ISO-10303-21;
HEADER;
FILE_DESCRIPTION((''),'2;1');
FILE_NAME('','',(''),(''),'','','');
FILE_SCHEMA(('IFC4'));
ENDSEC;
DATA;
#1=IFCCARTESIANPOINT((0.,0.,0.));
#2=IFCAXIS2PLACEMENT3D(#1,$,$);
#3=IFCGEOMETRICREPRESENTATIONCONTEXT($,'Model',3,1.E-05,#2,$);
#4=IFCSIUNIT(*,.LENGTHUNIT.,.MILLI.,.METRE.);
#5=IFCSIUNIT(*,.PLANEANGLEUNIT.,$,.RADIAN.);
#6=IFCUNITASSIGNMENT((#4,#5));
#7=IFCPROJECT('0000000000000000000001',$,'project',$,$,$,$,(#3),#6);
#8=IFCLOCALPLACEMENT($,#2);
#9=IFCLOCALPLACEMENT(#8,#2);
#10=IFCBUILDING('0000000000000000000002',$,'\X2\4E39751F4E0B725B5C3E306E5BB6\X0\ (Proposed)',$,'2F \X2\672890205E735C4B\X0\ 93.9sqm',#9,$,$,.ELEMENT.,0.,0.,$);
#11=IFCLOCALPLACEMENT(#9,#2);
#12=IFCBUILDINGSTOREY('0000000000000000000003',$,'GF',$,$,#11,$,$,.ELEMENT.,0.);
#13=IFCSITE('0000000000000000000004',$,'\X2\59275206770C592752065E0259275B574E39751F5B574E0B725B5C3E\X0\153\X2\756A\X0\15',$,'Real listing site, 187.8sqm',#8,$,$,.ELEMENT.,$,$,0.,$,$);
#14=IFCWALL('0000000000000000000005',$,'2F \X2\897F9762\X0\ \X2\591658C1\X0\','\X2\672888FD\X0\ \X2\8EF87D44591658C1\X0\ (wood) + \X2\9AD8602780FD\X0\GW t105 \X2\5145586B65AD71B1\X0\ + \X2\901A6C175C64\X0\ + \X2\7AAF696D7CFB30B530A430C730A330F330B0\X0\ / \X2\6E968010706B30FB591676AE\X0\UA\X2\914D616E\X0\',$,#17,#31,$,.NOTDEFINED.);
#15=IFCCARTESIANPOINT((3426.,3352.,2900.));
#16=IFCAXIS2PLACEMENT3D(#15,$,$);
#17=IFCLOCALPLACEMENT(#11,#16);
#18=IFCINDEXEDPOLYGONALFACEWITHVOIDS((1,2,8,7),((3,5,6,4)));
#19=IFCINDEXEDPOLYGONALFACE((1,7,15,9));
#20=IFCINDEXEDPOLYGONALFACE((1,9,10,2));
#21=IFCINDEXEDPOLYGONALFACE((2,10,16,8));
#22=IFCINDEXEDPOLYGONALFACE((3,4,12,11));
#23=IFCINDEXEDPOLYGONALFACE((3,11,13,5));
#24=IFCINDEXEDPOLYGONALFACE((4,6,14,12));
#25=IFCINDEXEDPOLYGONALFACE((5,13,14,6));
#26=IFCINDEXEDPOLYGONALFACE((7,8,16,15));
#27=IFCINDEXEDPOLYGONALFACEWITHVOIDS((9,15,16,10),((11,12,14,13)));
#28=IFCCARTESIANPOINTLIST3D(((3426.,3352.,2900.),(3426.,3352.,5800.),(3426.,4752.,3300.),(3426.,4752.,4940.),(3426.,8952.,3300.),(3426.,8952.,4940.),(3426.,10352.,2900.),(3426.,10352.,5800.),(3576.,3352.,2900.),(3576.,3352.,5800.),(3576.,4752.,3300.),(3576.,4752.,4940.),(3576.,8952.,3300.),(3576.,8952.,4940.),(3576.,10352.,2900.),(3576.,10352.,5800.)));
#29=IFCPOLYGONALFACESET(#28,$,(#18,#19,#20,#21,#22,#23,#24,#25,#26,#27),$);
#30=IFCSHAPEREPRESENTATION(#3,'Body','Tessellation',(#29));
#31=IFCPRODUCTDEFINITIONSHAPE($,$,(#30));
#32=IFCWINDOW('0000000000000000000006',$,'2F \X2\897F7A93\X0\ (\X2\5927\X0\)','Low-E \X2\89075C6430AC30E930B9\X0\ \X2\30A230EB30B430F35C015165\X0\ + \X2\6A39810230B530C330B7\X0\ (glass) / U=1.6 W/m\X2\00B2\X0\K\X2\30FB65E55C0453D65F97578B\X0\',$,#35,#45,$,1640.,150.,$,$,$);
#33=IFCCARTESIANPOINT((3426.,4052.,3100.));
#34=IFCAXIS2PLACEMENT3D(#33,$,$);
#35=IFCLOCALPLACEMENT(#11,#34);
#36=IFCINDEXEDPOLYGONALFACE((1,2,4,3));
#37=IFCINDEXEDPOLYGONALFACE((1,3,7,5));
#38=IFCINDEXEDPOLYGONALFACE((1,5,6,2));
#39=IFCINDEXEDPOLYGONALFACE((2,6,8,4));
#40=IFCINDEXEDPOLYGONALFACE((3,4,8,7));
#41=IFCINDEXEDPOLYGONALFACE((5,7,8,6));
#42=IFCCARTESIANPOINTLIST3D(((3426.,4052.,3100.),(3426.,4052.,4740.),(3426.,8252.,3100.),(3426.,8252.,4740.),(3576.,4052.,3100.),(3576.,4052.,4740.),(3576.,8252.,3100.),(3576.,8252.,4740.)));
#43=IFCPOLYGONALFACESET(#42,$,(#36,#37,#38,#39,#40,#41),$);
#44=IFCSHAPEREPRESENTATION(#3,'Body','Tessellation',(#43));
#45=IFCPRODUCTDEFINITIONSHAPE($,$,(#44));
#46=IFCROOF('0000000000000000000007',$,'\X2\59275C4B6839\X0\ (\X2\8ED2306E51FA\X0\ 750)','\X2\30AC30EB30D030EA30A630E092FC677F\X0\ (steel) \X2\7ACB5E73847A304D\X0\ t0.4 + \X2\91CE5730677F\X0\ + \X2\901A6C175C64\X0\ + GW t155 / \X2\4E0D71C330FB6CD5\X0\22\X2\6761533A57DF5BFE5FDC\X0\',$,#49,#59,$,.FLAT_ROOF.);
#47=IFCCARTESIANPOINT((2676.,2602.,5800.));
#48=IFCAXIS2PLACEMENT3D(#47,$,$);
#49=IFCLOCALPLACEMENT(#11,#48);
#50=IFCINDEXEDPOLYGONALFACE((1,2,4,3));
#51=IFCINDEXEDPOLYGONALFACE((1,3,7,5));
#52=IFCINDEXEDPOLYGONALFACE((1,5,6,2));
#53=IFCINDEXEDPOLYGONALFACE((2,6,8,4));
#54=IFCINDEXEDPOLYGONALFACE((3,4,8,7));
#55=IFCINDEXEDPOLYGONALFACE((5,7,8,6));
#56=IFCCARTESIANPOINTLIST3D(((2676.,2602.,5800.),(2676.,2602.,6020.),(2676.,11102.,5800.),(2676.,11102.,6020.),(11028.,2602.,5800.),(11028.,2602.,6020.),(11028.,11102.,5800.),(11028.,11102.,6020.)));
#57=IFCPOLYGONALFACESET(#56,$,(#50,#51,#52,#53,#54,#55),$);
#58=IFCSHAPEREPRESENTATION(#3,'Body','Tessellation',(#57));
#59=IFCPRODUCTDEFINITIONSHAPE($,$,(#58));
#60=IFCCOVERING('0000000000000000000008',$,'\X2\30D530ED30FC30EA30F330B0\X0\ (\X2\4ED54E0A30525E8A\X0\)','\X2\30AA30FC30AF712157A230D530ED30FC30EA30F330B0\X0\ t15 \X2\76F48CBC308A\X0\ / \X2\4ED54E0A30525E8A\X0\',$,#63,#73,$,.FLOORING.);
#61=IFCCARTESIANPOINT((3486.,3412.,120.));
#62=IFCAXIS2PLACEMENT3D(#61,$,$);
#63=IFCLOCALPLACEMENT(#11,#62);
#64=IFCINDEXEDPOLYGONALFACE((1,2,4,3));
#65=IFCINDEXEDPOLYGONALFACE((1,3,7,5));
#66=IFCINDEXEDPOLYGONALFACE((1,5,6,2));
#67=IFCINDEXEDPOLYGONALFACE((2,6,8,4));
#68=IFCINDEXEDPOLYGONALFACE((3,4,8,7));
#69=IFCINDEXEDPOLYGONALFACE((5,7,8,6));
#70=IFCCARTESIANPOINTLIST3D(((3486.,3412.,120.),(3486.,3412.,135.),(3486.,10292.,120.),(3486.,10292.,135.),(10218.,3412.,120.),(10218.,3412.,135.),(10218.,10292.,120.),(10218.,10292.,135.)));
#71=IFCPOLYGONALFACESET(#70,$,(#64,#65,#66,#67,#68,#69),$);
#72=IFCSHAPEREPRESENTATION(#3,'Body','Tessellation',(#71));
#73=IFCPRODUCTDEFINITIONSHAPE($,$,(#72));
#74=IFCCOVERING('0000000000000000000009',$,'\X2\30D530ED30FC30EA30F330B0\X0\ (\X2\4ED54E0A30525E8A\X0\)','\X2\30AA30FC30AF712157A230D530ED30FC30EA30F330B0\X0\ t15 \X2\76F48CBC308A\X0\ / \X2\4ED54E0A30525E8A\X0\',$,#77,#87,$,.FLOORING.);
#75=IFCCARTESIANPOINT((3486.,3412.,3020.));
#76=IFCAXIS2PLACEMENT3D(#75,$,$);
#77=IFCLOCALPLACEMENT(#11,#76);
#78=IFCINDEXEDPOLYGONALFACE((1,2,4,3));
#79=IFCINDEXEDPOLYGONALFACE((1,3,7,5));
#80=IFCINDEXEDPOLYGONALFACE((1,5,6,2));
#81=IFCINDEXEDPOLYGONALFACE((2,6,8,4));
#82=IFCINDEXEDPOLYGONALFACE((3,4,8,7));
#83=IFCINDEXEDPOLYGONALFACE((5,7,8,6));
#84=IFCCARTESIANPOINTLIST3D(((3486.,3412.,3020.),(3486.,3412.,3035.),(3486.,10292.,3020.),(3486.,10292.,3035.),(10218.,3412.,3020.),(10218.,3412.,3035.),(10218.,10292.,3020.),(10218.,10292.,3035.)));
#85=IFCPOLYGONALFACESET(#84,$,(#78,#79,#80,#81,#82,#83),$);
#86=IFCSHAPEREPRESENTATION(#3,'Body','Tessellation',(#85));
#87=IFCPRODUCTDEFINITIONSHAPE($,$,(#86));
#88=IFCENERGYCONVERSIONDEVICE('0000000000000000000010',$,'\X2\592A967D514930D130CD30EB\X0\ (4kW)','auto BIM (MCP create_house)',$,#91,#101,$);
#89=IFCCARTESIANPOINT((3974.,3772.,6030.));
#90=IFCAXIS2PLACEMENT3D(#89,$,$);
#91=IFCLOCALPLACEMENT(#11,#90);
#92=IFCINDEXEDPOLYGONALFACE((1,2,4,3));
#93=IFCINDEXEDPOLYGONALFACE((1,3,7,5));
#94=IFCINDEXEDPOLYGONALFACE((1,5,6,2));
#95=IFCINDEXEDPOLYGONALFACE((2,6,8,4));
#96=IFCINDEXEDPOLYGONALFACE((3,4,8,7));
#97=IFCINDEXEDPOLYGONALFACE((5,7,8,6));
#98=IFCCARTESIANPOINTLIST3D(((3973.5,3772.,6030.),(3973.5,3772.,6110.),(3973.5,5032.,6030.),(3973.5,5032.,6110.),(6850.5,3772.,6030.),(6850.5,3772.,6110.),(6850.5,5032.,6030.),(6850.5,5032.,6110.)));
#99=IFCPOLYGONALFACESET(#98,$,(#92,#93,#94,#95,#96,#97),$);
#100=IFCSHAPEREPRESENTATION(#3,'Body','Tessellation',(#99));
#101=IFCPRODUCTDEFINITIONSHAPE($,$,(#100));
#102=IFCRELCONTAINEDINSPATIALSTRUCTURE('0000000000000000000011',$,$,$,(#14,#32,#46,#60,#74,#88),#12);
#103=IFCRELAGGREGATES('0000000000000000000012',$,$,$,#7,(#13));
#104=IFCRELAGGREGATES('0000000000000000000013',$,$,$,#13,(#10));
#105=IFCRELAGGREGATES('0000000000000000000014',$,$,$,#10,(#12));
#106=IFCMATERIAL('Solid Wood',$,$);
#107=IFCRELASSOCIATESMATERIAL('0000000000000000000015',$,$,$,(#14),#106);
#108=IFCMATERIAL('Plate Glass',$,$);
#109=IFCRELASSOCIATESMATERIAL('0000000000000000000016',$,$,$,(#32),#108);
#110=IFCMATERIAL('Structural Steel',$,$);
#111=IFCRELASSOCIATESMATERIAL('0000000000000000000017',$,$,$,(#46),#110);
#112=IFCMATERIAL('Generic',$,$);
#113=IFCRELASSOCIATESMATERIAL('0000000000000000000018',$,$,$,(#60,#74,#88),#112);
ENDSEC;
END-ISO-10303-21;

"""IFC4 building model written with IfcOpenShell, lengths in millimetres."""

from ifc_helpers import new_model, si_unit, frame, frame_2d, origin, place, context, project, spatial, rectangle, extrude, material, element, fill, save


model = new_model("IFC4")

# Units and contexts
model_context = context("Model", 3, precision=1e-05, world=origin())
ifc_project = project(units=[si_unit("LENGTHUNIT", "METRE", prefix="MILLI"), si_unit("PLANEANGLEUNIT", "RADIAN")], contexts=[model_context])

# Site, building, storey
site_placement = place(None, origin())
site = spatial("IfcSite", under=ifc_project, at=site_placement, Name="大分県大分市大字丹生字下牛尾153番15", ObjectType="Real listing site, 187.8sqm", CompositionType="ELEMENT", RefElevation=0.0)
building_placement = place(site_placement, origin())
building = spatial("IfcBuilding", under=site, at=building_placement, Name="丹生下牛尾の家 (Proposed)", ObjectType="2F 木造平屋 93.9sqm", CompositionType="ELEMENT", ElevationOfRefHeight=0.0, ElevationOfTerrain=0.0)
storey_placement = place(building_placement, origin())
storey = spatial("IfcBuildingStorey", under=building, at=storey_placement, Name="GF", CompositionType="ELEMENT", Elevation=0.0)

# Shared definitions
ifc_material_1 = material(Name="Solid Wood")

# Shared definitions
ifc_material_2 = material(Name="Plate Glass")

# Wall, opening, window
wall_1_placement = place(storey_placement, frame((3426.0, 3352.0, 2900.0)))
wall_1 = element("IfcWall", 1, at=wall_1_placement, inside=storey, material=ifc_material_1, Name="2F 西面 外壁", Description="木製 軸組外壁 (wood) + 高性能GW t105 充填断熱 + 通気層 + 窯業系サイディング / 準耐火・外皮UA配慮", PredefinedType="NOTDEFINED", context=model_context, shape_type="SweptSolid", body=[
    extrude(rectangle(XDim=150.0, YDim=7000.0, at=frame_2d((75.0, 3500.0))), frame((3426.0, 3352.0, 2900.0)), (0.0, 0.0, 1.0), 2900.0),
])
opening_1_placement = place(storey_placement, frame((3426.0, 4052.0, 3100.0)))
opening_1 = element("IfcOpeningElement", 2, at=opening_1_placement, cuts=wall_1, PredefinedType="NOTDEFINED", context=model_context, shape_type="SweptSolid", body=[
    extrude(rectangle(XDim=150.0, YDim=4200.0, at=frame_2d((75.0, 2100.0))), frame((3426.0, 4052.0, 3100.0)), (0.0, 0.0, 1.0), 1640.0),
])
window_1_placement = place(storey_placement, frame((3426.0, 4052.0, 3100.0)))
window_1 = element("IfcWindow", 3, at=window_1_placement, inside=storey, material=ifc_material_2, Name="2F 西窓 (大)", Description="Low-E 複層ガラス アルゴン封入 + 樹脂サッシ (glass) / U=1.6 W/m²K・日射取得型", OverallHeight=1640.0, OverallWidth=150.0, context=model_context, shape_type="SweptSolid", body=[
    extrude(rectangle(XDim=150.0, YDim=4200.0, at=frame_2d((75.0, 2100.0))), frame((3426.0, 4052.0, 3100.0)), (0.0, 0.0, 1.0), 1640.0),
])
fill(opening_1, window_1)

# Roof
ifc_material_3 = material(Name="Structural Steel")
roof_placement = place(storey_placement, frame((2676.0, 2602.0, 5800.0)))
element("IfcRoof", 4, at=roof_placement, inside=storey, material=ifc_material_3, Name="大屋根 (軒の出 750)", Description="ガルバリウム鋼板 (steel) 立平葺き t0.4 + 野地板 + 通気層 + GW t155 / 不燃・法22条区域対応", PredefinedType="FLAT_ROOF", context=model_context, shape_type="SweptSolid", body=[
    extrude(rectangle(XDim=8352.0, YDim=8500.0, at=frame_2d((4176.0, 4250.0))), frame((2676.0, 2602.0, 5800.0)), (0.0, 0.0, 1.0), 220.0),
])

# Coverings
ifc_material_4 = material(Name="Generic")
covering_1_placement = place(storey_placement, frame((3486.0, 3412.0, 120.0)))
element("IfcCovering", 5, at=covering_1_placement, inside=storey, material=ifc_material_4, Name="フローリング (仕上げ床)", Description="オーク無垢フローリング t15 直貼り / 仕上げ床", PredefinedType="FLOORING", context=model_context, shape_type="SweptSolid", body=[
    extrude(rectangle(XDim=6732.0, YDim=6880.0, at=frame_2d((3366.0, 3440.0))), frame((3486.0, 3412.0, 120.0)), (0.0, 0.0, 1.0), 15.0),
])
covering_2_placement = place(storey_placement, frame((3486.0, 3412.0, 3020.0)))
element("IfcCovering", 6, at=covering_2_placement, inside=storey, material=ifc_material_4, Name="フローリング (仕上げ床)", Description="オーク無垢フローリング t15 直貼り / 仕上げ床", PredefinedType="FLOORING", context=model_context, shape_type="SweptSolid", body=[
    extrude(rectangle(XDim=6732.0, YDim=6880.0, at=frame_2d((3366.0, 3440.0))), frame((3486.0, 3412.0, 3020.0)), (0.0, 0.0, 1.0), 15.0),
])

# Energy conversion device
energy_conversion_device_placement = place(storey_placement, frame((3974.0, 3772.0, 6030.0)))
element("IfcEnergyConversionDevice", 7, at=energy_conversion_device_placement, inside=storey, material=ifc_material_4, Name="太陽光パネル (4kW)", Description="auto BIM (MCP create_house)", context=model_context, shape_type="SweptSolid", body=[
    extrude(rectangle(XDim=2877.0, YDim=1260.0, at=frame_2d((1438.0, 630.0))), frame((3974.0, 3772.0, 6030.0)), (0.0, 0.0, 1.0), 80.0),
])

save(model, "model.ifc")
